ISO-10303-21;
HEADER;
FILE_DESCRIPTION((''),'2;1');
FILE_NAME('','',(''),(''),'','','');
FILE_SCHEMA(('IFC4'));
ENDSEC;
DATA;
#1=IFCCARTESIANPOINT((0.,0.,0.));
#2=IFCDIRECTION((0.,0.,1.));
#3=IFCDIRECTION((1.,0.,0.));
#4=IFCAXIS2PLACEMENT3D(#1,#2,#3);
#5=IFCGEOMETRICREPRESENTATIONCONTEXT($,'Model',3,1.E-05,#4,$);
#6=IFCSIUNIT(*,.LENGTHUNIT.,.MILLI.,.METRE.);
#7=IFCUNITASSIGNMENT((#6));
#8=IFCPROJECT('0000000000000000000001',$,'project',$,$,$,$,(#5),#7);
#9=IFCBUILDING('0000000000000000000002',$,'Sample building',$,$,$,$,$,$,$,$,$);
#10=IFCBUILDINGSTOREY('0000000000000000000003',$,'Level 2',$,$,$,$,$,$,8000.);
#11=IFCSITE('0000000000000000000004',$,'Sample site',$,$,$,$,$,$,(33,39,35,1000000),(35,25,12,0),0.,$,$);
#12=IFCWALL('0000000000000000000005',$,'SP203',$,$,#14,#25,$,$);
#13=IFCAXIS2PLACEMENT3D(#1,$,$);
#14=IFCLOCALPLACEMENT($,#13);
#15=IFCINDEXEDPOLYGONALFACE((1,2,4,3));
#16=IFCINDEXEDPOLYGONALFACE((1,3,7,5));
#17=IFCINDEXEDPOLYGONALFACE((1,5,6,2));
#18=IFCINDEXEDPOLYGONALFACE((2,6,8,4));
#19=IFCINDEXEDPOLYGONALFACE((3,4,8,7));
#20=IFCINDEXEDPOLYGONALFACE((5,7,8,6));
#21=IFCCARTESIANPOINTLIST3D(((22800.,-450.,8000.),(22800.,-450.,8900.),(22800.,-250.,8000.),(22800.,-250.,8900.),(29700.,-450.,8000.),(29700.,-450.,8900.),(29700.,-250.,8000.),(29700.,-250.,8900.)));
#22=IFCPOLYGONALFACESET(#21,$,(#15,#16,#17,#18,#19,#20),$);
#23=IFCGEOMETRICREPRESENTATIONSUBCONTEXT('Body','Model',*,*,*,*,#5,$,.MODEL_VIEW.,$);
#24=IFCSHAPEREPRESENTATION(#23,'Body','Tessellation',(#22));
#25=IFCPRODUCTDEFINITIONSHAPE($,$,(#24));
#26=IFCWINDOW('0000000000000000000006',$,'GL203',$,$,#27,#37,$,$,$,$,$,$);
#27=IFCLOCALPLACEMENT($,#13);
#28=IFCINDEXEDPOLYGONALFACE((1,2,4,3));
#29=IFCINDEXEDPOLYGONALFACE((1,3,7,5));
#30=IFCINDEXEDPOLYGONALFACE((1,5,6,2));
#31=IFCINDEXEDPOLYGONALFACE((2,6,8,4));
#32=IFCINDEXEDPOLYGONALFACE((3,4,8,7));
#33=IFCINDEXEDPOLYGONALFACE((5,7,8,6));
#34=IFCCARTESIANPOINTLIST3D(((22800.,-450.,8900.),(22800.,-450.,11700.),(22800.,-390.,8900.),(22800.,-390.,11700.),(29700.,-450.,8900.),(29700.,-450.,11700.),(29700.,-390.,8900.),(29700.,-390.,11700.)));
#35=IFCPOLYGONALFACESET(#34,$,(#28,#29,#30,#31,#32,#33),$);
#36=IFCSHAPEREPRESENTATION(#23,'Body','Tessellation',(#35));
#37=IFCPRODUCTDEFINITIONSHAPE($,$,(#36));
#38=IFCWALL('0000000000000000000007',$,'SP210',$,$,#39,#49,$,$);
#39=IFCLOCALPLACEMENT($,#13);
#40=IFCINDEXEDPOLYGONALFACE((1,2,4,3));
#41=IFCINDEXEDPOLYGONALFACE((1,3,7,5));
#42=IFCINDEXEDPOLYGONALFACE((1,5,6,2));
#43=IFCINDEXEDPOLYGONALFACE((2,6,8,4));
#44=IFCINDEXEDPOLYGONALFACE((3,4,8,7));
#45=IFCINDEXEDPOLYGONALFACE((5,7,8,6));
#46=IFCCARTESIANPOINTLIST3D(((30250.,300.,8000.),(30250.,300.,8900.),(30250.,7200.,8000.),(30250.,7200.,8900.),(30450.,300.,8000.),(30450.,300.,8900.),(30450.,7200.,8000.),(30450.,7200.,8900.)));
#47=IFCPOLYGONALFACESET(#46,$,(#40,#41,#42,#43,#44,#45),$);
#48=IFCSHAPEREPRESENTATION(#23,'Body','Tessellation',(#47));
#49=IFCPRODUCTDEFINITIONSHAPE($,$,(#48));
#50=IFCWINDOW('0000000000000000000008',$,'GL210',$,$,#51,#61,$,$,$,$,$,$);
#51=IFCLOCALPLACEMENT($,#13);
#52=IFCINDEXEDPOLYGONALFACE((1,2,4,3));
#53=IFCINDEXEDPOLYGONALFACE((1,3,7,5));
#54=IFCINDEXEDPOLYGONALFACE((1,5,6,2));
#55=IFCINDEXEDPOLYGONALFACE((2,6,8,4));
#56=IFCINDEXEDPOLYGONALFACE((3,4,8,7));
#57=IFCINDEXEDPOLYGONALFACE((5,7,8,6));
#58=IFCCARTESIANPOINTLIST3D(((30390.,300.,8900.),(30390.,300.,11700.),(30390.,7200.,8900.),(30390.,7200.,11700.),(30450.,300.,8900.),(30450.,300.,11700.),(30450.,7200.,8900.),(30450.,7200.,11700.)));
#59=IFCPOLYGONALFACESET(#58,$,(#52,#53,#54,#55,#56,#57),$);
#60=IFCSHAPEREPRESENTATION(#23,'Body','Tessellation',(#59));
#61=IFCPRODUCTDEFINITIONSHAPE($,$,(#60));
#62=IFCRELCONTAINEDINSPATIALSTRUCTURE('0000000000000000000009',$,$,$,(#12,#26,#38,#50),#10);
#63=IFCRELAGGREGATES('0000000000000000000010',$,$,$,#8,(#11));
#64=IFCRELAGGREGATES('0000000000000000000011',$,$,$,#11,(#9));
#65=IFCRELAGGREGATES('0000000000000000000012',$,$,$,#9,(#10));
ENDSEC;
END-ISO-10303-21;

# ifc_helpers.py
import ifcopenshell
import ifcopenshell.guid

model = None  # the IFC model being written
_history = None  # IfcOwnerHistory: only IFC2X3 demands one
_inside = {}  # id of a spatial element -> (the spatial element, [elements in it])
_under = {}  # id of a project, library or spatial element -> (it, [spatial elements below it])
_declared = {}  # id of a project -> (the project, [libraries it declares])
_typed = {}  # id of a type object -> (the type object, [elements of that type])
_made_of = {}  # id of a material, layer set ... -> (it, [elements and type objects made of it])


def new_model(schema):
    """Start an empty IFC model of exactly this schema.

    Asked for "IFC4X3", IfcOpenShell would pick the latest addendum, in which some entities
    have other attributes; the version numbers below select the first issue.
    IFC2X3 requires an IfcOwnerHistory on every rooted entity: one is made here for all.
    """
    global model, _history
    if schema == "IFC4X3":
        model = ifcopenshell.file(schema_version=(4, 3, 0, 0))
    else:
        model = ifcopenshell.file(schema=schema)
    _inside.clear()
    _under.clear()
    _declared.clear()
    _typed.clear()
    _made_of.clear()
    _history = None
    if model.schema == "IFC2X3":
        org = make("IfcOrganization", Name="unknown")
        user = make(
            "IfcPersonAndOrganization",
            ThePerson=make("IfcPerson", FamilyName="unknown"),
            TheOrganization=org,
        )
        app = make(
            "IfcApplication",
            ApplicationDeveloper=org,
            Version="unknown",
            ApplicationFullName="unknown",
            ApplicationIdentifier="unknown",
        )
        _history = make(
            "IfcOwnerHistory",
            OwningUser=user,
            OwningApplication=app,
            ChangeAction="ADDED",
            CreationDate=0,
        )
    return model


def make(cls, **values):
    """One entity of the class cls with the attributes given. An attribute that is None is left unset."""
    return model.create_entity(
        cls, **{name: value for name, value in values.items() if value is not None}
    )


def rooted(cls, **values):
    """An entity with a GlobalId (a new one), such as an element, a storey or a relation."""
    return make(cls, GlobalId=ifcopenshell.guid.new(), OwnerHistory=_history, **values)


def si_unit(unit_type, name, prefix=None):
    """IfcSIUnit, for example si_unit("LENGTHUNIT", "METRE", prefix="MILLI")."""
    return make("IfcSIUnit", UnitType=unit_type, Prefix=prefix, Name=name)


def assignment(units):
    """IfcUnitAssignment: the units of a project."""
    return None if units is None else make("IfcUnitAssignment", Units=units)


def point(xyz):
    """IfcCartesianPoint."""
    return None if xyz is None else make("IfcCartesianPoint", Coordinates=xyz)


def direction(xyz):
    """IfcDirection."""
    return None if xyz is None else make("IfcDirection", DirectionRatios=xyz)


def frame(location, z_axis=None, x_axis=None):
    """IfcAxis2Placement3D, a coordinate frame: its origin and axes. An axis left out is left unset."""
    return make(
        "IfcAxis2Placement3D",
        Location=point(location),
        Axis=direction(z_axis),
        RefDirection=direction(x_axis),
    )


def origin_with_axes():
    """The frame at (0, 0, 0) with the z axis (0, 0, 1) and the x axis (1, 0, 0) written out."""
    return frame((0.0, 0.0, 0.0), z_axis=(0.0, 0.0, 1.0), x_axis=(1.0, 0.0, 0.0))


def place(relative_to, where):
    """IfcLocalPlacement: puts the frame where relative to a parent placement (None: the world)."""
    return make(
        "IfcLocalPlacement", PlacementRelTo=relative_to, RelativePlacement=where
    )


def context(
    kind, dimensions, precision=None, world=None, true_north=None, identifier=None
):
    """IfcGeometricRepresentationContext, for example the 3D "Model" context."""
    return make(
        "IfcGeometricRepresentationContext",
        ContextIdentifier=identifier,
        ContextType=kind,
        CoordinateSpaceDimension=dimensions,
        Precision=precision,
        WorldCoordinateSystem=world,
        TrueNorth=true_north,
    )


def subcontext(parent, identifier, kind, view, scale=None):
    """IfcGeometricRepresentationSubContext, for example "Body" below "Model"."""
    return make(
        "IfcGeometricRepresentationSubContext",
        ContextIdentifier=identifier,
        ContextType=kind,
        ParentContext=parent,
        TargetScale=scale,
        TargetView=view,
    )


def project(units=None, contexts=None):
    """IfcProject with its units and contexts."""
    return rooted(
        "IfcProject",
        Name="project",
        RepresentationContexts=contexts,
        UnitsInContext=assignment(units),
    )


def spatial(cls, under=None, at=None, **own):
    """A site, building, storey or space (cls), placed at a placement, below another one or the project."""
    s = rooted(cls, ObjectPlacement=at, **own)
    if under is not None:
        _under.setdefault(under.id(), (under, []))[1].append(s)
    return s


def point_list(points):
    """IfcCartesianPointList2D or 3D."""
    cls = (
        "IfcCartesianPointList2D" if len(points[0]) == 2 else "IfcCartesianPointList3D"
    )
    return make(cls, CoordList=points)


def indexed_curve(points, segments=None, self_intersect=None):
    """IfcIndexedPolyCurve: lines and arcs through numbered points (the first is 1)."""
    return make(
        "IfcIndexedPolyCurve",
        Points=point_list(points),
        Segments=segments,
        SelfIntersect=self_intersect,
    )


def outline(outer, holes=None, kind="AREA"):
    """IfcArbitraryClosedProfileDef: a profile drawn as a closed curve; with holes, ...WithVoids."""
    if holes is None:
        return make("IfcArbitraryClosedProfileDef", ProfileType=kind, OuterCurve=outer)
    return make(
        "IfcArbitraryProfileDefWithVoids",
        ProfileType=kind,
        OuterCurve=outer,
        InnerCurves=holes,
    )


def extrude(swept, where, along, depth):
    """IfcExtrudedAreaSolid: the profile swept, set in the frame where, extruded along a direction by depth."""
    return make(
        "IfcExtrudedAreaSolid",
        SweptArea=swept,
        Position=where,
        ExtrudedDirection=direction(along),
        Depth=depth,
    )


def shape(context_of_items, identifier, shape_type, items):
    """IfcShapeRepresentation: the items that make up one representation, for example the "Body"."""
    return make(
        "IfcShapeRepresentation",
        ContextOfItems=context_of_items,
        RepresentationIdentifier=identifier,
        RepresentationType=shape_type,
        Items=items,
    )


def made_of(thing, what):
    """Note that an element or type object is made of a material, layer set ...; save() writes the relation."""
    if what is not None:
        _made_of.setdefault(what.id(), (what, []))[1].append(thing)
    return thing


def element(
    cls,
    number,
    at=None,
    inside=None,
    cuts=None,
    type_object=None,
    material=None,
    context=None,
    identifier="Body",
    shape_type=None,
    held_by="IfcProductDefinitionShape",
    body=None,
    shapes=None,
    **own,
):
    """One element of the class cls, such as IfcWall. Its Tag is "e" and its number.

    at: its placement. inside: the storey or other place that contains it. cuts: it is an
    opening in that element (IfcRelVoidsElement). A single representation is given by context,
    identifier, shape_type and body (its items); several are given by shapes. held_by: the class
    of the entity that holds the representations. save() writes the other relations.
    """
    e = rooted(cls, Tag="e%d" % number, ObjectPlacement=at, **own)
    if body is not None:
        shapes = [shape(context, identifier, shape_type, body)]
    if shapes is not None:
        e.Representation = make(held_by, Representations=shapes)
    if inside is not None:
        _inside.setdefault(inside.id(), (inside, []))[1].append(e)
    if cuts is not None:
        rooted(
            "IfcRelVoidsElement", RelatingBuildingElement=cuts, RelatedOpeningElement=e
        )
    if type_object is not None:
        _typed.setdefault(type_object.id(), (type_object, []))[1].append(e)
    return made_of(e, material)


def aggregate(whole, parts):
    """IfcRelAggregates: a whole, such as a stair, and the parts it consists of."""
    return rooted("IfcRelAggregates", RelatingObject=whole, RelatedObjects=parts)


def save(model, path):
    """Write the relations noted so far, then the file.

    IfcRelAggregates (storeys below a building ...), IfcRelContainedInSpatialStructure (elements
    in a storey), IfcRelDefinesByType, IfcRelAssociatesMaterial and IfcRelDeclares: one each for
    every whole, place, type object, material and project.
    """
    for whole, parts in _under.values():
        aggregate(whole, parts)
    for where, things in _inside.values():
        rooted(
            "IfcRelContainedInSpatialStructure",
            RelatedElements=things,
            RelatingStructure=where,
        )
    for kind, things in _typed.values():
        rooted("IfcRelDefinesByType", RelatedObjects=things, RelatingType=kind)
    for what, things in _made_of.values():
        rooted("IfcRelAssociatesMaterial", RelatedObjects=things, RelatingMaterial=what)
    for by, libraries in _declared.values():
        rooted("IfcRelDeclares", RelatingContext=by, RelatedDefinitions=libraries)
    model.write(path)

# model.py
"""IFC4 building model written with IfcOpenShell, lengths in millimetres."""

from ifc_helpers import new_model, si_unit, frame, origin_with_axes, place, context, subcontext, project, spatial, indexed_curve, outline, extrude, element, save


model = new_model("IFC4")

# Units and contexts
model_context = context("Model", 3, precision=1e-05, world=origin_with_axes())
body_context = subcontext(model_context, "Body", "Model", "MODEL_VIEW")
ifc_project = project(units=[si_unit("LENGTHUNIT", "METRE", prefix="MILLI")], contexts=[model_context])

# Site, building, storey
site = spatial("IfcSite", under=ifc_project, Name="Sample site", RefLatitude=(33, 39, 35, 1000000), RefLongitude=(35, 25, 12, 0), RefElevation=0.0)
building = spatial("IfcBuilding", under=site, Name="Sample building")
storey = spatial("IfcBuildingStorey", under=building, Name="Level 2", Elevation=8000.0)

# Wall
wall_1_placement = place(None, frame((22800.0, -450.0, 8000.0), z_axis=(0.0, 0.0, 1.0), x_axis=(1.0, 0.0, 0.0)))
element("IfcWall", 1, at=wall_1_placement, inside=storey, Name="SP203", context=body_context, shape_type="SweptSolid", body=[
    extrude(outline(indexed_curve([(0.0, 0.0), (0.0, 200.0), (6900.0, 200.0), (6900.0, 0.0), (0.0, 0.0)], self_intersect=False)), origin_with_axes(), (0.0, 0.0, 1.0), 900.0),
])

# Window
window_1_placement = place(None, frame((22800.0, -450.0, 8900.0), z_axis=(0.0, 0.0, 1.0), x_axis=(1.0, 0.0, 0.0)))
element("IfcWindow", 2, at=window_1_placement, inside=storey, Name="GL203", context=body_context, shape_type="SweptSolid", body=[
    extrude(outline(indexed_curve([(0.0, 0.0), (0.0, 60.0), (6900.0, 60.0), (6900.0, 0.0), (0.0, 0.0)], self_intersect=False)), origin_with_axes(), (0.0, 0.0, 1.0), 2800.0),
])

# Wall
wall_2_placement = place(None, frame((30450.0, 300.0, 8000.0), z_axis=(0.0, 0.0, 1.0), x_axis=(0.0, 1.0, 0.0)))
element("IfcWall", 3, at=wall_2_placement, inside=storey, Name="SP210", context=body_context, shape_type="SweptSolid", body=[
    extrude(outline(indexed_curve([(0.0, 0.0), (0.0, 200.0), (6900.0, 200.0), (6900.0, 0.0), (0.0, 0.0)], self_intersect=False)), origin_with_axes(), (0.0, 0.0, 1.0), 900.0),
])

# Window
window_2_placement = place(None, frame((30450.0, 300.0, 8900.0), z_axis=(0.0, 0.0, 1.0), x_axis=(0.0, 1.0, 0.0)))
element("IfcWindow", 4, at=window_2_placement, inside=storey, Name="GL210", context=body_context, shape_type="SweptSolid", body=[
    extrude(outline(indexed_curve([(0.0, 0.0), (0.0, 60.0), (6900.0, 60.0), (6900.0, 0.0), (0.0, 0.0)], self_intersect=False)), origin_with_axes(), (0.0, 0.0, 1.0), 2800.0),
])

save(model, "model.ifc")
